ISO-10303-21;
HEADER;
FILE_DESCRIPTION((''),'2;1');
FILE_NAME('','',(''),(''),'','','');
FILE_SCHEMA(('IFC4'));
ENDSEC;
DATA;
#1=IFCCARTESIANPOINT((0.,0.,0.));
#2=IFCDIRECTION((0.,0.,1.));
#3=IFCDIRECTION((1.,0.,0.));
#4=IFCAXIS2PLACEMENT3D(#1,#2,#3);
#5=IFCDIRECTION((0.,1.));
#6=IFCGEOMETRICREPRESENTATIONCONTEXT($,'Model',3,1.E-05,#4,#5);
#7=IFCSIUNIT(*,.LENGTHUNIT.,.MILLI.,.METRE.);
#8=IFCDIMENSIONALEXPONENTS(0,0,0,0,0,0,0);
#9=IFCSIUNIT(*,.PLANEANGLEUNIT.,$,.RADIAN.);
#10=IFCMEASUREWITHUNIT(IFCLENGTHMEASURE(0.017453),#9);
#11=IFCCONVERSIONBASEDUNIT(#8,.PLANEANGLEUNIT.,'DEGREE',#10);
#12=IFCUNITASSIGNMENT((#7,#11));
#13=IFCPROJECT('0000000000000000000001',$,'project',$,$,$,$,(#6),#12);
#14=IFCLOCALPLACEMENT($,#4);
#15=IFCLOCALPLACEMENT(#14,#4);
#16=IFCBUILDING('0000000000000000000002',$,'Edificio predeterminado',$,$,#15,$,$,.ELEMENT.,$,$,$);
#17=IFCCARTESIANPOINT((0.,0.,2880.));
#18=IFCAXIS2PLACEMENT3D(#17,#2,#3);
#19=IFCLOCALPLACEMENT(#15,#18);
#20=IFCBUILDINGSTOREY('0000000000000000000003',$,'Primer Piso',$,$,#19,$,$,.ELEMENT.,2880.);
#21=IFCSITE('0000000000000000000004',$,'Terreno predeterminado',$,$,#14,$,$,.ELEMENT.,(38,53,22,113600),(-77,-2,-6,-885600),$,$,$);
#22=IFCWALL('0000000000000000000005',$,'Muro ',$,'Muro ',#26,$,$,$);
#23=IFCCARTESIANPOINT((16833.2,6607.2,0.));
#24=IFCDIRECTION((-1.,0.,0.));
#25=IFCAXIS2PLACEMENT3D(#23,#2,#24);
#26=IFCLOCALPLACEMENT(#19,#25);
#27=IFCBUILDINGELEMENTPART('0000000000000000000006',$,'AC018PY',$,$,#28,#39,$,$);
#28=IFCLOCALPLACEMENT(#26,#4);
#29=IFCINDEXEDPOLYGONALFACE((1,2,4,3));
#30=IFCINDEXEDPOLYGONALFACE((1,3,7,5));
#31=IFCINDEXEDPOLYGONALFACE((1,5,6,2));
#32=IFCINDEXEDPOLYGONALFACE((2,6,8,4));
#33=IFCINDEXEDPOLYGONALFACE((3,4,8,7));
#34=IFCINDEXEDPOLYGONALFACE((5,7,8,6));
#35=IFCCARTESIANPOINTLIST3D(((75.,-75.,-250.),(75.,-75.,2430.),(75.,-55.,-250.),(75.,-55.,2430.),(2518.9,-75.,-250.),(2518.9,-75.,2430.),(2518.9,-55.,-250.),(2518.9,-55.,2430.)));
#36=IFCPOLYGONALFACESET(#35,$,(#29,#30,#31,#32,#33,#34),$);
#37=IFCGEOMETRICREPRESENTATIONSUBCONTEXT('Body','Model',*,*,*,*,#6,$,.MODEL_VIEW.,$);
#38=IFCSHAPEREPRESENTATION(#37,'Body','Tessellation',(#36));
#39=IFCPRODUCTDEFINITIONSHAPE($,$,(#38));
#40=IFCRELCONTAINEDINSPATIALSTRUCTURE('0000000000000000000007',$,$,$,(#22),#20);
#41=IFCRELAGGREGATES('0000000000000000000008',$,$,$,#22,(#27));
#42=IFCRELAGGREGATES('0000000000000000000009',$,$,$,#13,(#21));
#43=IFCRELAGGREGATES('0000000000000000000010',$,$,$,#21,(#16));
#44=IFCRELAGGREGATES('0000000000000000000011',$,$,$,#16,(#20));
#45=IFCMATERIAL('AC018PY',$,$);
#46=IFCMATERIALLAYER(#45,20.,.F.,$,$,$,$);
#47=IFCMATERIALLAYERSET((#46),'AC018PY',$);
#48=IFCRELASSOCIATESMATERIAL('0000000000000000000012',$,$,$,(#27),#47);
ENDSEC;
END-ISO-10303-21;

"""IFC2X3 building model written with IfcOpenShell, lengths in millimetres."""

from ifc_helpers import new_model, entity, si_unit, converted_unit, direction, frame, origin_with_axes, place, context, subcontext, project, spatial, polyline, outline, extrude, material, layer, layer_set, layer_usage, element, aggregate, save


model = new_model("IFC2X3")

# Units and contexts
model_context = context("Model", 3, precision=1e-05, world=origin_with_axes(), true_north=direction((0.0, 1.0)))
body_context = subcontext(model_context, "Body", "Model", "MODEL_VIEW")
ifc_project = project(units=[si_unit("LENGTHUNIT", "METRE", prefix="MILLI"), converted_unit("PLANEANGLEUNIT", "DEGREE", entity("IfcLengthMeasure", 0.017453), si_unit("PLANEANGLEUNIT", "RADIAN"), dimensions=[0, 0, 0, 0, 0, 0, 0])], contexts=[model_context])

# Site, building, storey
site_placement = place(None, origin_with_axes())
site = spatial("IfcSite", under=ifc_project, at=site_placement, Name="Terreno predeterminado", CompositionType="ELEMENT", RefLatitude=(38, 53, 22, 113600), RefLongitude=(-77, -2, -6, -885600))
building_placement = place(site_placement, origin_with_axes())
building = spatial("IfcBuilding", under=site, at=building_placement, Name="Edificio predeterminado", CompositionType="ELEMENT")
storey_placement = place(building_placement, frame((0.0, 0.0, 2880.0), z_axis=(0.0, 0.0, 1.0), x_axis=(1.0, 0.0, 0.0)))
storey = spatial("IfcBuildingStorey", under=building, at=storey_placement, Name="Primer Piso", CompositionType="ELEMENT", Elevation=2880.0)

# Wall, building element part
wall_1_placement = place(storey_placement, frame((16833.2, 6607.2, 0.0), z_axis=(0.0, 0.0, 1.0), x_axis=(-1.0, 0.0, 0.0)))
wall_1 = element("IfcWall", 1, at=wall_1_placement, inside=storey, Name="Muro ", ObjectType="Muro ")
ifc_material_1 = material(Name="AC018PY")
ifc_layer_1 = layer(ifc_material_1, 20.0, ventilated=False)
ifc_layer_set_1 = layer_set([ifc_layer_1], Name="AC018PY")
ifc_layer_usage_1 = layer_usage(ifc_layer_set_1, "AXIS2", "NEGATIVE", 55.0)
building_element_part_1_placement = place(wall_1_placement, origin_with_axes())
building_element_part_1 = element("IfcBuildingElementPart", 2, at=building_element_part_1_placement, material=ifc_layer_usage_1, Name="AC018PY", context=body_context, shape_type="SweptSolid", body=[
    extrude(outline(polyline([(2518.9, -55.0), (2518.9, -75.0), (75.0, -75.0), (75.0, -55.0), (2518.9, -55.0)])), frame((0.0, 0.0, -250.0), z_axis=(0.0, 0.0, 1.0), x_axis=(1.0, 0.0, 0.0)), (0.0, 0.0, 1.0), 2680.0),
])
aggregate(wall_1, [building_element_part_1])

save(model, "model.ifc")
